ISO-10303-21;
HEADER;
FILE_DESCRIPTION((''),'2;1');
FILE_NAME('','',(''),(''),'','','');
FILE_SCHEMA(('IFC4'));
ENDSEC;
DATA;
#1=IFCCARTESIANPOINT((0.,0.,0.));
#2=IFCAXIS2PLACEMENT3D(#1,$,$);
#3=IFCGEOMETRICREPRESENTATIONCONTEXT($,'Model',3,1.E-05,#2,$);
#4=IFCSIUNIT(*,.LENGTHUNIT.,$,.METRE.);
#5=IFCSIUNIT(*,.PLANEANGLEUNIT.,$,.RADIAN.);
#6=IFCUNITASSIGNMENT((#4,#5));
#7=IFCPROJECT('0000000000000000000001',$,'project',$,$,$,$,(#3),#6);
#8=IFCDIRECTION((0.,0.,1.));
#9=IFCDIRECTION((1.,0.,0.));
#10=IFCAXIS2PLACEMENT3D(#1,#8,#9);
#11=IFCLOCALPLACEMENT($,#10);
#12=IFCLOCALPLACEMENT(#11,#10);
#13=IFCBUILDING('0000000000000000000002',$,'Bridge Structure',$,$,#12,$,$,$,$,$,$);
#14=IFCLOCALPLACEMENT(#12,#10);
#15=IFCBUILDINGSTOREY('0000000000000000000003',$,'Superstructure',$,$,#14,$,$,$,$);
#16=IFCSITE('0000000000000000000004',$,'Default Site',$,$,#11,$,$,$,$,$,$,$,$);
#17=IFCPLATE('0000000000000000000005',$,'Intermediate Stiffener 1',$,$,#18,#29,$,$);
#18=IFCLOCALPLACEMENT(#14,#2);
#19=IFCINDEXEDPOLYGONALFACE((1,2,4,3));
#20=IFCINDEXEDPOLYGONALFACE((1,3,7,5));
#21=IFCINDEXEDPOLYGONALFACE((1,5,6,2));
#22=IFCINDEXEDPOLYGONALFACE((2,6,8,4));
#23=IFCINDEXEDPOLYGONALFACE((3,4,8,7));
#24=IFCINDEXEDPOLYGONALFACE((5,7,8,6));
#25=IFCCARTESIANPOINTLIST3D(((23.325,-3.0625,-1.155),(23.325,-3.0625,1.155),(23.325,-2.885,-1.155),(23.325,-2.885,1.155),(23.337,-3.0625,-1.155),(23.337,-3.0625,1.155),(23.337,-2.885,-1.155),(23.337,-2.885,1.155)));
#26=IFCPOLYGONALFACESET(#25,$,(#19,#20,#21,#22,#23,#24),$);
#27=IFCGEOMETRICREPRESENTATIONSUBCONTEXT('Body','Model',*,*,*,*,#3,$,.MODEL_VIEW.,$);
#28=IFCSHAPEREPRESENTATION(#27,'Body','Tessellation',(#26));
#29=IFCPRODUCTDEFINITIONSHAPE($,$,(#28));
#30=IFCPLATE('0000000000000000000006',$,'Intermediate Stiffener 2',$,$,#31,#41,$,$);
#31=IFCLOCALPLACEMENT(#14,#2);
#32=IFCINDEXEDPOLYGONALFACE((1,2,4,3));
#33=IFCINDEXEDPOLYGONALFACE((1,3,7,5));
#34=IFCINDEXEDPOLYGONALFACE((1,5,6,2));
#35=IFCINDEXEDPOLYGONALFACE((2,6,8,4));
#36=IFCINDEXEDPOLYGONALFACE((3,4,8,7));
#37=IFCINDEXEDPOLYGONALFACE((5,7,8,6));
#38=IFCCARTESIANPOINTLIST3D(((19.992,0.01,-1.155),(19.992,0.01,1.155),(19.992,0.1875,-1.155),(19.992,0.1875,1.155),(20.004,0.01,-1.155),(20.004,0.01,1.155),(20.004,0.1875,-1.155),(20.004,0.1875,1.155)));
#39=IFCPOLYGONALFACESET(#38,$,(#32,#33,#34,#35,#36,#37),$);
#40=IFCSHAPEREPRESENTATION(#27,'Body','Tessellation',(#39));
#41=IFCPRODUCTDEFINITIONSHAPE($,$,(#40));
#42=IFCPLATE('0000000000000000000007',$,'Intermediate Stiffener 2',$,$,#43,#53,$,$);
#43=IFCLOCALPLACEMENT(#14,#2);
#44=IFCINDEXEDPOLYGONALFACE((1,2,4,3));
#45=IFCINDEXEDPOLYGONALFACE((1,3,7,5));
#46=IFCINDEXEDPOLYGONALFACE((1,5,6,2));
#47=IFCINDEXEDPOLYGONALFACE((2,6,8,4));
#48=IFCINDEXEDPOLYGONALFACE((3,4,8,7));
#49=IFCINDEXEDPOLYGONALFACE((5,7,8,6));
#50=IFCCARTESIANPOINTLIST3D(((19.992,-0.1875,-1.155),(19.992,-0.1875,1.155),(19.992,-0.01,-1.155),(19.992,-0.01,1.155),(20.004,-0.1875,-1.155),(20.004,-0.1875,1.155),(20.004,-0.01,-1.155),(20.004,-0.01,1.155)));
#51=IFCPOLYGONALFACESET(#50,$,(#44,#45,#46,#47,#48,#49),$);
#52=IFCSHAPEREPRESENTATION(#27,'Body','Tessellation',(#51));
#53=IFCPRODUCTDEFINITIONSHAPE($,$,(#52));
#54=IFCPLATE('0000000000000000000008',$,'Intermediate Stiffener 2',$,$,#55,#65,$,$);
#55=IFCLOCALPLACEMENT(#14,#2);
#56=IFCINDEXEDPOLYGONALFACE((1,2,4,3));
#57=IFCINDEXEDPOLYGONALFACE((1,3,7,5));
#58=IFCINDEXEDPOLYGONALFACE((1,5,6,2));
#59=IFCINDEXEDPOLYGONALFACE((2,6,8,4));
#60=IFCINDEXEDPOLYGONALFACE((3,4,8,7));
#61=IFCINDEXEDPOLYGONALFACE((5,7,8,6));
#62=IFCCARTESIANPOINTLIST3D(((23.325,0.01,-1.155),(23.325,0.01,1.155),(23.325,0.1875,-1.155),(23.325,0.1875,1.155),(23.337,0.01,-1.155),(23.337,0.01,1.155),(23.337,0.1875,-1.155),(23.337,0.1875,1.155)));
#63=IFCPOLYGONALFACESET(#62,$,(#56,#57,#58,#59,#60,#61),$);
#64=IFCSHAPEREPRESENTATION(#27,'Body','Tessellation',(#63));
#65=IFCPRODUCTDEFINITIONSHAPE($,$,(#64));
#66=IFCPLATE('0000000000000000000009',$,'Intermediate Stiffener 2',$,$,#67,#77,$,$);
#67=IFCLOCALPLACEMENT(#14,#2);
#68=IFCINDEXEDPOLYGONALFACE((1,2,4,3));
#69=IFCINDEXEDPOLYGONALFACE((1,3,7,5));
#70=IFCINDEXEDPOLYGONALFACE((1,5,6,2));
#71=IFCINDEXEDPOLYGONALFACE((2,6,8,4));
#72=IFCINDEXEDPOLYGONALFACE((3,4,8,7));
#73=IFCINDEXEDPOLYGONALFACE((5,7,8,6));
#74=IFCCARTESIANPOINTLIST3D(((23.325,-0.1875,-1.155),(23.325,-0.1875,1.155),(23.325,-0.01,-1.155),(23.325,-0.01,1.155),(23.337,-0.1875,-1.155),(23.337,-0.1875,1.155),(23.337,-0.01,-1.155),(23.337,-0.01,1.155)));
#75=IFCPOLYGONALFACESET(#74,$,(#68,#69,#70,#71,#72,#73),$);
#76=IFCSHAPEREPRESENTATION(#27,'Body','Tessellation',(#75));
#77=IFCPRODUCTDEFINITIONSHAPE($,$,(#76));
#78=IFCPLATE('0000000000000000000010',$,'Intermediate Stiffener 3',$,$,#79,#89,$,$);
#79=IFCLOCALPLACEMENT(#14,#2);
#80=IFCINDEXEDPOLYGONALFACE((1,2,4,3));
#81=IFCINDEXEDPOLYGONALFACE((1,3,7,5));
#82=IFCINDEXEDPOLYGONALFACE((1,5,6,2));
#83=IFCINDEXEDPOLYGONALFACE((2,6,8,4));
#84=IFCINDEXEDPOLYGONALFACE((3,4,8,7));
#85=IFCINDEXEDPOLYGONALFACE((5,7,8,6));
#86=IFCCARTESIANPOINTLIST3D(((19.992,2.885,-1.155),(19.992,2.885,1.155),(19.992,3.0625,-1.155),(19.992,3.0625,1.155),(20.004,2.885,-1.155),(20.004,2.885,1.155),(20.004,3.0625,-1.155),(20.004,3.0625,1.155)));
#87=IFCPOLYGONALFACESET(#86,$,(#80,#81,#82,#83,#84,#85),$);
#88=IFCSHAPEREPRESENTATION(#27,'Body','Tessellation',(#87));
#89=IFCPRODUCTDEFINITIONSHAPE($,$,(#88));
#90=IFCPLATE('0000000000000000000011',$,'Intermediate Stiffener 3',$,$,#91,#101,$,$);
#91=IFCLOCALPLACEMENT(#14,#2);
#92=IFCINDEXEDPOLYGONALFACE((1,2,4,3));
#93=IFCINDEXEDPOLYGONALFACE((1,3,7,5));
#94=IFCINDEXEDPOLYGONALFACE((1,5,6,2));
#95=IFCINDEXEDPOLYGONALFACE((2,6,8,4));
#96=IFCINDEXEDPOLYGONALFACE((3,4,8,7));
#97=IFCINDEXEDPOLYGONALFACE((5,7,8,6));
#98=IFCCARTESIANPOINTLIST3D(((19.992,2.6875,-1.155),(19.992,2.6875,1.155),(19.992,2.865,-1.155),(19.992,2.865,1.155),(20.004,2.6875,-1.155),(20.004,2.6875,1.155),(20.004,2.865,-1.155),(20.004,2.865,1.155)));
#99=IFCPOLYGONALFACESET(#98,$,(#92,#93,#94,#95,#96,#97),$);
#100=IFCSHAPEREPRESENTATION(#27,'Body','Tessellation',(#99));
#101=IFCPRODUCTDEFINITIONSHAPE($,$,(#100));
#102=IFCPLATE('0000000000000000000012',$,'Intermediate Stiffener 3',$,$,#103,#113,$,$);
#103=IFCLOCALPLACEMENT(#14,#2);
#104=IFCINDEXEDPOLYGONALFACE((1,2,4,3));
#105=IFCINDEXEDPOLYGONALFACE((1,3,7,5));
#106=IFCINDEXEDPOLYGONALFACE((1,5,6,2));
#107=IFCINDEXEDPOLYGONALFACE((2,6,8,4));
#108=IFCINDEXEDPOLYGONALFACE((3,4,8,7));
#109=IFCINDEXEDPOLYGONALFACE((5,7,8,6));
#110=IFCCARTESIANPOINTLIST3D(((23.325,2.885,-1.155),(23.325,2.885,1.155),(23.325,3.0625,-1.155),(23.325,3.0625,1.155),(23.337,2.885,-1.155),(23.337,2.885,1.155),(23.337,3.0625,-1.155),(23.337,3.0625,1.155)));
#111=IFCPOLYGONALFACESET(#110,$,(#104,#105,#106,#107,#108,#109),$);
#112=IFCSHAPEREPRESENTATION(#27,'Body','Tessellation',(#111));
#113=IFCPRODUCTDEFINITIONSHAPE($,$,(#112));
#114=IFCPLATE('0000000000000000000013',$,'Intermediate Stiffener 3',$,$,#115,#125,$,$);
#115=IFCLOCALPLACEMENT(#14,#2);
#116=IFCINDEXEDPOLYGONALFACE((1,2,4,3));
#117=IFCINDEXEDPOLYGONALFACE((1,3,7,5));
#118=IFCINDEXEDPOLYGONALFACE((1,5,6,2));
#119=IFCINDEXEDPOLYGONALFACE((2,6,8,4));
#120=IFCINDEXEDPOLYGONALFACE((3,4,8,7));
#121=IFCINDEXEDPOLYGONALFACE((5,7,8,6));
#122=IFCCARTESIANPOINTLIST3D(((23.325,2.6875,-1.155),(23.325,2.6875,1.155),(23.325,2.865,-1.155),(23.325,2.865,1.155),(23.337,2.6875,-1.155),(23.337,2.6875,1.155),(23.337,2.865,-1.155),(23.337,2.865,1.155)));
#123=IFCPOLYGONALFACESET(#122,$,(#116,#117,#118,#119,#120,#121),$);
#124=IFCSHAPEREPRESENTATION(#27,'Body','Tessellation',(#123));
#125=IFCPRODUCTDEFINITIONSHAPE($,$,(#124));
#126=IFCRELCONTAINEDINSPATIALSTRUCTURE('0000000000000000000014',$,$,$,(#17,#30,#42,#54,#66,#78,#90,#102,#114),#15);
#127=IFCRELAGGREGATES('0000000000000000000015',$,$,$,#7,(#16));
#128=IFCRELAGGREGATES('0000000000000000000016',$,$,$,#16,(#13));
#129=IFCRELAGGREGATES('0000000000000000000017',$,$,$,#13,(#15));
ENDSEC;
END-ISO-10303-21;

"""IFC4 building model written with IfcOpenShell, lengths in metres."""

from ifc_helpers import new_model, si_unit, frame, origin, origin_with_axes, origin_2d_with_axis, place, context, subcontext, project, spatial, rectangle, extrude, element, save


model = new_model("IFC4")

# Units and contexts
model_context = context("Model", 3, precision=1e-05, world=origin())
body_context = subcontext(model_context, "Body", "Model", "MODEL_VIEW")
ifc_project = project(units=[si_unit("LENGTHUNIT", "METRE"), si_unit("PLANEANGLEUNIT", "RADIAN")], contexts=[model_context])

# Site, building, storey
site_placement = place(None, origin_with_axes())
site = spatial("IfcSite", under=ifc_project, at=site_placement, Name="Default Site")
building_placement = place(site_placement, origin_with_axes())
building = spatial("IfcBuilding", under=site, at=building_placement, Name="Bridge Structure")
storey_placement = place(building_placement, origin_with_axes())
storey = spatial("IfcBuildingStorey", under=building, at=storey_placement, Name="Superstructure")

# Plates
for number, where, z_axis, x_axis, name in (
    (1, (23.331, -2.9737, -1.155), (0.0, 0.0, 1.0), (1.0, 0.0, 0.0), "Intermediate Stiffener 1"),
    (2, (19.998, 0.0988, -1.155), (0.0, 0.0, 1.0), (1.0, 0.0, 0.0), "Intermediate Stiffener 2"),
    (3, (19.998, -0.0988, -1.155), (0.0, 0.0, 1.0), (1.0, 0.0, 0.0), "Intermediate Stiffener 2"),
    (4, (23.331, 0.0988, -1.155), (0.0, 0.0, 1.0), (1.0, 0.0, 0.0), "Intermediate Stiffener 2"),
    (5, (23.331, -0.0988, -1.155), (0.0, 0.0, 1.0), (1.0, 0.0, 0.0), "Intermediate Stiffener 2"),
    (6, (19.998, 2.9737, -1.155), (0.0, 0.0, 1.0), (1.0, 0.0, 0.0), "Intermediate Stiffener 3"),
    (7, (19.998, 2.7763, -1.155), (0.0, 0.0, 1.0), (1.0, 0.0, 0.0), "Intermediate Stiffener 3"),
    (8, (23.331, 2.9737, -1.155), (0.0, 0.0, 1.0), (1.0, 0.0, 0.0), "Intermediate Stiffener 3"),
    (9, (23.331, 2.7763, -1.155), (0.0, 0.0, 1.0), (1.0, 0.0, 0.0), "Intermediate Stiffener 3"),
):
    element("IfcPlate", number, at=place(storey_placement, frame(where, z_axis=z_axis, x_axis=x_axis)), inside=storey, Name=name, context=body_context, shape_type="SweptSolid", body=[
        extrude(rectangle(XDim=0.012, YDim=0.1775, at=origin_2d_with_axis()), origin_with_axes(), (0.0, 0.0, 1.0), 2.31),
    ])

save(model, "model.ifc")
